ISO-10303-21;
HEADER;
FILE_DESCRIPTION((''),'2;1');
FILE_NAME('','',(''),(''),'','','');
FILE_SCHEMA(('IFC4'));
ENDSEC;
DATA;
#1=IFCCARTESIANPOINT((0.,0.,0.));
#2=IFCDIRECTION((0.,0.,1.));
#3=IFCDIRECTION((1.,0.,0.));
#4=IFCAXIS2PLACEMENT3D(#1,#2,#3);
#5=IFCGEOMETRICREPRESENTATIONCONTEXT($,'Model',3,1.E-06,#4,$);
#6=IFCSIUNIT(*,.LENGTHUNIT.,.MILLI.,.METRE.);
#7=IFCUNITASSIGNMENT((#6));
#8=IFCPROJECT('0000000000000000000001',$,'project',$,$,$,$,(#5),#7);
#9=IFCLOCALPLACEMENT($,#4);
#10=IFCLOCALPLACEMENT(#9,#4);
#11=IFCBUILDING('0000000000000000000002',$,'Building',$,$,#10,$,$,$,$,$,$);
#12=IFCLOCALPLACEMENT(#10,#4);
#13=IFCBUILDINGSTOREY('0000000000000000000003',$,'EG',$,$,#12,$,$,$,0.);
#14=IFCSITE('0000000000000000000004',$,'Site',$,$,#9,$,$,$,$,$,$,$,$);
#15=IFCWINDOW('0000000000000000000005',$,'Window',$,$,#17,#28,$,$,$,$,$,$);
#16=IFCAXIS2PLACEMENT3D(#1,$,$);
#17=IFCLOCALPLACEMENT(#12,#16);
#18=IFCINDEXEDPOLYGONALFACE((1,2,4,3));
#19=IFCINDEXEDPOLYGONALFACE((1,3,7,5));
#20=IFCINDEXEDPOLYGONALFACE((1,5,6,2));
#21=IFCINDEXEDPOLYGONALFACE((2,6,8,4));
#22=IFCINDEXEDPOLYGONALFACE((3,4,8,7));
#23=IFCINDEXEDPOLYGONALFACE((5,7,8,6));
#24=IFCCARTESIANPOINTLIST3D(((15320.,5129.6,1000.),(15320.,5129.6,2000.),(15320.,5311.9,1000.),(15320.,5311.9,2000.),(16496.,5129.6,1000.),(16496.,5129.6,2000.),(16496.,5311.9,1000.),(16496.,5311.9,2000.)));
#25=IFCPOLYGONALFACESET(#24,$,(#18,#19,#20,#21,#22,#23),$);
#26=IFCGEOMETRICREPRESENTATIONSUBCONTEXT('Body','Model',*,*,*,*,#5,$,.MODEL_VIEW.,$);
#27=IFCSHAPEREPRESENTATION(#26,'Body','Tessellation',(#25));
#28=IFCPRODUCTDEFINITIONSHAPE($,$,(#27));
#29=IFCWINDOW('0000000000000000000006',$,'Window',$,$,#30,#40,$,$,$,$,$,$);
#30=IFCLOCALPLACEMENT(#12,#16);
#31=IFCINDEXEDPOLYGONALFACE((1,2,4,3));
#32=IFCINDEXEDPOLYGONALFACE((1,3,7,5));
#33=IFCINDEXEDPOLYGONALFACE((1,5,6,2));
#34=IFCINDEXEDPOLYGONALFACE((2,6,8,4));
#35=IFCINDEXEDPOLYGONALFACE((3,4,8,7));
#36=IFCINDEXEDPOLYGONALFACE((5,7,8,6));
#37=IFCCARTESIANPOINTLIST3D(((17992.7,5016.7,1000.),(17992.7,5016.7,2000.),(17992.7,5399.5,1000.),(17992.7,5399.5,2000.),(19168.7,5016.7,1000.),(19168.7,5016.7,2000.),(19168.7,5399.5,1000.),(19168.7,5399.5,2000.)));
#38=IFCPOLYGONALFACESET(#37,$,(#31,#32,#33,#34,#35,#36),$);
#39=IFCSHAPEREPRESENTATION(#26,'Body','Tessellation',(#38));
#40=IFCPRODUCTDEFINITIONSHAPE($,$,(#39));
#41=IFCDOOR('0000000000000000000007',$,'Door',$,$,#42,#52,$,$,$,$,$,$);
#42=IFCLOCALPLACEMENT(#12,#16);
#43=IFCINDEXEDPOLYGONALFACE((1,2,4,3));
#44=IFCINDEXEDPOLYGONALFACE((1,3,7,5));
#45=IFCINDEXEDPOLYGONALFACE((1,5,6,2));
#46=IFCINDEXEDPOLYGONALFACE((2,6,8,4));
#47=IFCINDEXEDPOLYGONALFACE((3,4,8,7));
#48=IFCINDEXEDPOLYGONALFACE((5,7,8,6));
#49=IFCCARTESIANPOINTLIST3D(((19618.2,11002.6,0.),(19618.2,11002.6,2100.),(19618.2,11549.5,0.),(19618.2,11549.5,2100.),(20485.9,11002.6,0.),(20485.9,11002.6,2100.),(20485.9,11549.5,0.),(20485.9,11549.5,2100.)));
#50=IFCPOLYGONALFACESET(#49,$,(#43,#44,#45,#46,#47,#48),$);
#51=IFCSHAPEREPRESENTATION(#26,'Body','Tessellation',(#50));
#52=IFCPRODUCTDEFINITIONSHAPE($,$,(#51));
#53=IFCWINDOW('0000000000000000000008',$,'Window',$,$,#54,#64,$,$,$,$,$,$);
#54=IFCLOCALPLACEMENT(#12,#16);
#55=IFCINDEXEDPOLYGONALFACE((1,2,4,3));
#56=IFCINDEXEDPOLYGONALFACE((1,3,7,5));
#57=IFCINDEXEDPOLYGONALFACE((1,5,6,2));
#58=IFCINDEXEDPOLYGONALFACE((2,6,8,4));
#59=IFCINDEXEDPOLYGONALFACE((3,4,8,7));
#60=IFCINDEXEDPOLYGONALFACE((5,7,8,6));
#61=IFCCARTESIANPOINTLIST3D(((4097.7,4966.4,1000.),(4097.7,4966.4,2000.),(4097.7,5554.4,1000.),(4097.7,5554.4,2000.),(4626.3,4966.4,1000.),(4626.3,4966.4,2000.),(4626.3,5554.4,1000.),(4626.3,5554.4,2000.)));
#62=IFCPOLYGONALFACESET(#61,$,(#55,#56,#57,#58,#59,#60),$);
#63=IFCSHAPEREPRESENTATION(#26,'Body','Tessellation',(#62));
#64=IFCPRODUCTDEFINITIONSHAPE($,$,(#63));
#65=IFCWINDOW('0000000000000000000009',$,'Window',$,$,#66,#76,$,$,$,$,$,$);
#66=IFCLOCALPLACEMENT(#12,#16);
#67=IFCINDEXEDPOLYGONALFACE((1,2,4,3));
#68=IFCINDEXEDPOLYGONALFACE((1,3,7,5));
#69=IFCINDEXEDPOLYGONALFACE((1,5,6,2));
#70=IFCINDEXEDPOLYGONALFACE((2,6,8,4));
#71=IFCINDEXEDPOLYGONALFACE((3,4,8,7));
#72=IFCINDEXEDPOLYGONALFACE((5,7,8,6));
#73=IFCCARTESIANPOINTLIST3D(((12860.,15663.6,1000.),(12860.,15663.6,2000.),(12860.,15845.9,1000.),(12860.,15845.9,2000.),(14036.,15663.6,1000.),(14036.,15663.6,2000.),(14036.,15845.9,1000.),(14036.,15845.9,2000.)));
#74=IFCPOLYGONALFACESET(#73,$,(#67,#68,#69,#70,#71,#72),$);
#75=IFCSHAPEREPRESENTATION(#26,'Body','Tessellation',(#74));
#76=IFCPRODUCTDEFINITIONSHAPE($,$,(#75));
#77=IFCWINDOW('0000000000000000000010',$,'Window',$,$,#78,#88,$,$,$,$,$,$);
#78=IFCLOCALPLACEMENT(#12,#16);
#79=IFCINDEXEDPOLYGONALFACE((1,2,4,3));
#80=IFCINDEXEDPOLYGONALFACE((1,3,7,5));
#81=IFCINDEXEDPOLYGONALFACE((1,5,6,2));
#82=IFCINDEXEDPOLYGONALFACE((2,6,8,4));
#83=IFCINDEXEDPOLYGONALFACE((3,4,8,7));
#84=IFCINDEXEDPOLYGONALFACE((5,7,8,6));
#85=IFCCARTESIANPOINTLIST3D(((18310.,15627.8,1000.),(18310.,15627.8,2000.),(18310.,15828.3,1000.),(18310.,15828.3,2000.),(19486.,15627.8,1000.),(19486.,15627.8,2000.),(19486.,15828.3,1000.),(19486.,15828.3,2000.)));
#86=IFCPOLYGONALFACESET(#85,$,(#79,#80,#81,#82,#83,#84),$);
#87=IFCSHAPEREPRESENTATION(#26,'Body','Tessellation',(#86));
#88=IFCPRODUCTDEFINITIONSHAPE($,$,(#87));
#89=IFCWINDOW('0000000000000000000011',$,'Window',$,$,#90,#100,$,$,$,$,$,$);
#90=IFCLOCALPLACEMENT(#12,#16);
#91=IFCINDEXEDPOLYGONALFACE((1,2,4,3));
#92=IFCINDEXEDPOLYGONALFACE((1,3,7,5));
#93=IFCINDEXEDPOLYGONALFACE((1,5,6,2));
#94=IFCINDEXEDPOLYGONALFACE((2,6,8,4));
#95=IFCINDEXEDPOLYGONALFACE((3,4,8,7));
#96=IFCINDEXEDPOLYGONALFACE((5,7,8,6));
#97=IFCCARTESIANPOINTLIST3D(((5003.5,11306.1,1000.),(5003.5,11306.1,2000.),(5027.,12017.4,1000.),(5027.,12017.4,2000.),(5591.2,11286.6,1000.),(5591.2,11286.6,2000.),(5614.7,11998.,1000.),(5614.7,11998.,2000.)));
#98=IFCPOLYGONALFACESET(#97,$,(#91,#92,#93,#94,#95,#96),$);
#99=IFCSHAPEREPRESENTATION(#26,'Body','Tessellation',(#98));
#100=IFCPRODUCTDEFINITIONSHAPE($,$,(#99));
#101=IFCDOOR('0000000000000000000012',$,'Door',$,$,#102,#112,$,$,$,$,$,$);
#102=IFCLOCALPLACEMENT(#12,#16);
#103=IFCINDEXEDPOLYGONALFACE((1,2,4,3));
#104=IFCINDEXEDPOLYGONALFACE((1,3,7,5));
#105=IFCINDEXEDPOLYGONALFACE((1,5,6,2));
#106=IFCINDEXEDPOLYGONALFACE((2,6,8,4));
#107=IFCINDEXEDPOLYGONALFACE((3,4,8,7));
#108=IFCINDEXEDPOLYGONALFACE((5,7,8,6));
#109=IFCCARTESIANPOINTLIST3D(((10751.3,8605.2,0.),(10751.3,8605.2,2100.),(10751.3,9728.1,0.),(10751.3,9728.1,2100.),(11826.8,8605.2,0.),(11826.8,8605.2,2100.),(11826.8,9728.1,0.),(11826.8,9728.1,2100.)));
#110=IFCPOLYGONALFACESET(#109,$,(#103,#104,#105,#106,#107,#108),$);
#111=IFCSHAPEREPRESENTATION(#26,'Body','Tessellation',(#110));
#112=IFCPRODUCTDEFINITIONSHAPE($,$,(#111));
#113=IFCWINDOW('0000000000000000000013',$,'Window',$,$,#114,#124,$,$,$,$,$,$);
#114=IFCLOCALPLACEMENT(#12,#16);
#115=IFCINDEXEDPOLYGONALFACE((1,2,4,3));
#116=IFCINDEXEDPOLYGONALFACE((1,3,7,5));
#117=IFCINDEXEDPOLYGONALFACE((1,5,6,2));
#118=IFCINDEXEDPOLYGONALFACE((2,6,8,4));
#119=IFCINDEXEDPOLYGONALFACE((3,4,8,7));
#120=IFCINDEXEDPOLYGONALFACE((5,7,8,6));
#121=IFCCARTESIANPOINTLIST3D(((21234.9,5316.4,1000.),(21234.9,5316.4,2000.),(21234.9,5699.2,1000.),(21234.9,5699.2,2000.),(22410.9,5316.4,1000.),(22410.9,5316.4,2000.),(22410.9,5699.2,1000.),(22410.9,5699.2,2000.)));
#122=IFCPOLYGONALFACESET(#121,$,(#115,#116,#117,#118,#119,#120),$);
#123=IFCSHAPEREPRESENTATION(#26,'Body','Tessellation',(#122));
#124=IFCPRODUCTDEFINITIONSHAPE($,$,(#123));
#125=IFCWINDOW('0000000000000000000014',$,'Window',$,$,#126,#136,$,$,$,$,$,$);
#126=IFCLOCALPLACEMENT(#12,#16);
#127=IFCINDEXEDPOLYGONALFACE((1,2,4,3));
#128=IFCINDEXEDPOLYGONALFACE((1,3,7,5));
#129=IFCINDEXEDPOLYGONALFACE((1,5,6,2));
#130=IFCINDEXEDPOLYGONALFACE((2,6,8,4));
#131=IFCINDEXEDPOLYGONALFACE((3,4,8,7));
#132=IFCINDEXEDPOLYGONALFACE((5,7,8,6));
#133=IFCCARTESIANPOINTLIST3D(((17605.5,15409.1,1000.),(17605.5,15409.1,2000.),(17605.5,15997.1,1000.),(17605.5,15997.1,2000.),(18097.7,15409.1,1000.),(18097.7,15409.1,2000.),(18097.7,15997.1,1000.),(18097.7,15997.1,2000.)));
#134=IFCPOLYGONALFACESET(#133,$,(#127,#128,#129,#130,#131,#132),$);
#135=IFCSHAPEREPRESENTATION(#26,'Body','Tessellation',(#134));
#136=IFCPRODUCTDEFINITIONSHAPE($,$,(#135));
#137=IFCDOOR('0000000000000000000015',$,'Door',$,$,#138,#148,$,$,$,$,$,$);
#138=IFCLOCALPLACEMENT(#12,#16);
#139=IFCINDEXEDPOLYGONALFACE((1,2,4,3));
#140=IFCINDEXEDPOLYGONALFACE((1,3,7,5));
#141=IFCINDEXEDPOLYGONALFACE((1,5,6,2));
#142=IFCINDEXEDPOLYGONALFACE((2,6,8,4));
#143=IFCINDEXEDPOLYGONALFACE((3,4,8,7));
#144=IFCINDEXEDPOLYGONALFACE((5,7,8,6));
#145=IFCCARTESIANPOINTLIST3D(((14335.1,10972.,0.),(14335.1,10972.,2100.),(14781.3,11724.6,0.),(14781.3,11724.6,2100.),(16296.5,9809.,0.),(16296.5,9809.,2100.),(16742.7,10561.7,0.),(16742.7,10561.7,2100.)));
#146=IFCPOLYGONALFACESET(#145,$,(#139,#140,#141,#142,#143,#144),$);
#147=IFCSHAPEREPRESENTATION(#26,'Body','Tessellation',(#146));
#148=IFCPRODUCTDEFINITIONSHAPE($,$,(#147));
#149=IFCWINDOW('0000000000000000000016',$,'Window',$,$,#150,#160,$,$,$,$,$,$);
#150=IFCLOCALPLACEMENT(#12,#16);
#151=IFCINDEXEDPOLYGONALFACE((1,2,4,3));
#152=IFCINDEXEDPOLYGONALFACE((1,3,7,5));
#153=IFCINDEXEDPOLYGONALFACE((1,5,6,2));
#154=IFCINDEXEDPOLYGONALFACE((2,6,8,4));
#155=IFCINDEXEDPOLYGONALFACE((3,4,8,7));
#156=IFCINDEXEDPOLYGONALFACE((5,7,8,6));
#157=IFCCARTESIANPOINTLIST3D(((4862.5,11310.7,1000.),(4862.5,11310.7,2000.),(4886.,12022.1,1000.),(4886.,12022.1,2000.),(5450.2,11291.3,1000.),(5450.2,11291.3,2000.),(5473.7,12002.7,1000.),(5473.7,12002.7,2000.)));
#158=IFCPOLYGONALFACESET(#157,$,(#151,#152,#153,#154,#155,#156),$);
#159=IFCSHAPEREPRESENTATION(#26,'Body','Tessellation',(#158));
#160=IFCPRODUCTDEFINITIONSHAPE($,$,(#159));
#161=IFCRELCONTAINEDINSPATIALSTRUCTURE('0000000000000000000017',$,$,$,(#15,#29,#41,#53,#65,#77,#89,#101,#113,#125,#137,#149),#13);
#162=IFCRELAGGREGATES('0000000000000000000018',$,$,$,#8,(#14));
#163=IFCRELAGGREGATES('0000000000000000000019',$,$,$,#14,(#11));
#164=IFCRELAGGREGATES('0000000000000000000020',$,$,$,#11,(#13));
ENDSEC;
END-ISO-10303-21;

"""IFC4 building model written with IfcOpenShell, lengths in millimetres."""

from ifc_helpers import new_model, si_unit, frame, origin_with_axes, place, context, subcontext, project, spatial, rectangle, extrude, element, save


model = new_model("IFC4")

# Units and contexts
model_context = context("Model", 3, precision=1e-06, world=origin_with_axes())
body_context = subcontext(model_context, "Body", "Model", "MODEL_VIEW")
ifc_project = project(units=[si_unit("LENGTHUNIT", "METRE", prefix="MILLI")], contexts=[model_context])

# Site, building, storey
site_placement = place(None, origin_with_axes())
site = spatial("IfcSite", under=ifc_project, at=site_placement, Name="Site")
building_placement = place(site_placement, origin_with_axes())
building = spatial("IfcBuilding", under=site, at=building_placement, Name="Building")
storey_placement = place(building_placement, origin_with_axes())
storey = spatial("IfcBuildingStorey", under=building, at=storey_placement, Name="EG", Elevation=0.0)

# Windows
window_1_placement = place(storey_placement, origin_with_axes())
element("IfcWindow", 1, at=window_1_placement, inside=storey, Name="Window", context=body_context, shape_type="SweptSolid", body=[
    extrude(rectangle(XDim=1176.0, YDim=182.3), frame((15908.0, 5220.7, 1000.0), z_axis=(0.0, 0.0, 1.0), x_axis=(1.0, 0.0, 0.0)), (0.0, 0.0, 1.0), 1000.0),
])
window_2_placement = place(storey_placement, origin_with_axes())
element("IfcWindow", 2, at=window_2_placement, inside=storey, Name="Window", context=body_context, shape_type="SweptSolid", body=[
    extrude(rectangle(XDim=1176.0, YDim=382.8), frame((18580.7, 5208.1, 1000.0), z_axis=(0.0, 0.0, 1.0), x_axis=(1.0, 0.0, 0.0)), (0.0, 0.0, 1.0), 1000.0),
])

# Door
door_1_placement = place(storey_placement, origin_with_axes())
element("IfcDoor", 3, at=door_1_placement, inside=storey, Name="Door", context=body_context, shape_type="SweptSolid", body=[
    extrude(rectangle(XDim=867.7, YDim=546.9), frame((20052.1, 11276.0, 0.0), z_axis=(0.0, 0.0, 1.0), x_axis=(1.0, 0.0, 0.0)), (0.0, 0.0, 1.0), 2100.0),
])

# Windows
window_3_placement = place(storey_placement, origin_with_axes())
element("IfcWindow", 4, at=window_3_placement, inside=storey, Name="Window", context=body_context, shape_type="SweptSolid", body=[
    extrude(rectangle(XDim=588.0, YDim=528.6), frame((4362.0, 5260.4, 1000.0), z_axis=(0.0, 0.0, 1.0), x_axis=(0.0, 1.0, 0.0)), (0.0, 0.0, 1.0), 1000.0),
])
window_4_placement = place(storey_placement, origin_with_axes())
element("IfcWindow", 5, at=window_4_placement, inside=storey, Name="Window", context=body_context, shape_type="SweptSolid", body=[
    extrude(rectangle(XDim=1176.0, YDim=182.3), frame((13448.0, 15754.8, 1000.0), z_axis=(0.0, 0.0, 1.0), x_axis=(1.0, 0.0, 0.0)), (0.0, 0.0, 1.0), 1000.0),
])
window_5_placement = place(storey_placement, origin_with_axes())
element("IfcWindow", 6, at=window_5_placement, inside=storey, Name="Window", context=body_context, shape_type="SweptSolid", body=[
    extrude(rectangle(XDim=1176.0, YDim=200.5), frame((18898.0, 15728.1, 1000.0), z_axis=(0.0, 0.0, 1.0), x_axis=(1.0, 0.0, 0.0)), (0.0, 0.0, 1.0), 1000.0),
])
window_6_placement = place(storey_placement, origin_with_axes())
element("IfcWindow", 7, at=window_6_placement, inside=storey, Name="Window", context=body_context, shape_type="SweptSolid", body=[
    extrude(rectangle(XDim=588.0, YDim=711.8), frame((5309.1, 11652.0, 1000.0), z_axis=(0.0, 0.0, 1.0), x_axis=(-0.999454, 0.03304, 0.0)), (0.0, 0.0, 1.0), 1000.0),
])

# Door
door_2_placement = place(storey_placement, origin_with_axes())
element("IfcDoor", 8, at=door_2_placement, inside=storey, Name="Door", context=body_context, shape_type="SweptSolid", body=[
    extrude(rectangle(XDim=1122.9, YDim=1075.5), frame((11289.1, 9166.7, 0.0), z_axis=(0.0, 0.0, 1.0), x_axis=(0.0, 1.0, 0.0)), (0.0, 0.0, 1.0), 2100.0),
])

# Windows
window_7_placement = place(storey_placement, origin_with_axes())
element("IfcWindow", 9, at=window_7_placement, inside=storey, Name="Window", context=body_context, shape_type="SweptSolid", body=[
    extrude(rectangle(XDim=1176.0, YDim=382.8), frame((21822.9, 5507.8, 1000.0), z_axis=(0.0, 0.0, 1.0), x_axis=(1.0, 0.0, 0.0)), (0.0, 0.0, 1.0), 1000.0),
])
window_8_placement = place(storey_placement, origin_with_axes())
element("IfcWindow", 10, at=window_8_placement, inside=storey, Name="Window", context=body_context, shape_type="SweptSolid", body=[
    extrude(rectangle(XDim=588.0, YDim=492.2), frame((17851.6, 15703.1, 1000.0), z_axis=(0.0, 0.0, 1.0), x_axis=(0.0, 1.0, 0.0)), (0.0, 0.0, 1.0), 1000.0),
])

# Door
door_3_placement = place(storey_placement, origin_with_axes())
element("IfcDoor", 11, at=door_3_placement, inside=storey, Name="Door", context=body_context, shape_type="SweptSolid", body=[
    extrude(rectangle(XDim=875.0, YDim=2280.3), frame((15538.9, 10766.8, 0.0), z_axis=(0.0, 0.0, 1.0), x_axis=(-0.510011, -0.860168, 0.0)), (0.0, 0.0, 1.0), 2100.0),
])

# Window
window_9_placement = place(storey_placement, origin_with_axes())
element("IfcWindow", 12, at=window_9_placement, inside=storey, Name="Window", context=body_context, shape_type="SweptSolid", body=[
    extrude(rectangle(XDim=588.0, YDim=711.8), frame((5168.1, 11656.7, 1000.0), z_axis=(0.0, 0.0, 1.0), x_axis=(-0.999454, 0.03304, 0.0)), (0.0, 0.0, 1.0), 1000.0),
])

save(model, "model.ifc")
